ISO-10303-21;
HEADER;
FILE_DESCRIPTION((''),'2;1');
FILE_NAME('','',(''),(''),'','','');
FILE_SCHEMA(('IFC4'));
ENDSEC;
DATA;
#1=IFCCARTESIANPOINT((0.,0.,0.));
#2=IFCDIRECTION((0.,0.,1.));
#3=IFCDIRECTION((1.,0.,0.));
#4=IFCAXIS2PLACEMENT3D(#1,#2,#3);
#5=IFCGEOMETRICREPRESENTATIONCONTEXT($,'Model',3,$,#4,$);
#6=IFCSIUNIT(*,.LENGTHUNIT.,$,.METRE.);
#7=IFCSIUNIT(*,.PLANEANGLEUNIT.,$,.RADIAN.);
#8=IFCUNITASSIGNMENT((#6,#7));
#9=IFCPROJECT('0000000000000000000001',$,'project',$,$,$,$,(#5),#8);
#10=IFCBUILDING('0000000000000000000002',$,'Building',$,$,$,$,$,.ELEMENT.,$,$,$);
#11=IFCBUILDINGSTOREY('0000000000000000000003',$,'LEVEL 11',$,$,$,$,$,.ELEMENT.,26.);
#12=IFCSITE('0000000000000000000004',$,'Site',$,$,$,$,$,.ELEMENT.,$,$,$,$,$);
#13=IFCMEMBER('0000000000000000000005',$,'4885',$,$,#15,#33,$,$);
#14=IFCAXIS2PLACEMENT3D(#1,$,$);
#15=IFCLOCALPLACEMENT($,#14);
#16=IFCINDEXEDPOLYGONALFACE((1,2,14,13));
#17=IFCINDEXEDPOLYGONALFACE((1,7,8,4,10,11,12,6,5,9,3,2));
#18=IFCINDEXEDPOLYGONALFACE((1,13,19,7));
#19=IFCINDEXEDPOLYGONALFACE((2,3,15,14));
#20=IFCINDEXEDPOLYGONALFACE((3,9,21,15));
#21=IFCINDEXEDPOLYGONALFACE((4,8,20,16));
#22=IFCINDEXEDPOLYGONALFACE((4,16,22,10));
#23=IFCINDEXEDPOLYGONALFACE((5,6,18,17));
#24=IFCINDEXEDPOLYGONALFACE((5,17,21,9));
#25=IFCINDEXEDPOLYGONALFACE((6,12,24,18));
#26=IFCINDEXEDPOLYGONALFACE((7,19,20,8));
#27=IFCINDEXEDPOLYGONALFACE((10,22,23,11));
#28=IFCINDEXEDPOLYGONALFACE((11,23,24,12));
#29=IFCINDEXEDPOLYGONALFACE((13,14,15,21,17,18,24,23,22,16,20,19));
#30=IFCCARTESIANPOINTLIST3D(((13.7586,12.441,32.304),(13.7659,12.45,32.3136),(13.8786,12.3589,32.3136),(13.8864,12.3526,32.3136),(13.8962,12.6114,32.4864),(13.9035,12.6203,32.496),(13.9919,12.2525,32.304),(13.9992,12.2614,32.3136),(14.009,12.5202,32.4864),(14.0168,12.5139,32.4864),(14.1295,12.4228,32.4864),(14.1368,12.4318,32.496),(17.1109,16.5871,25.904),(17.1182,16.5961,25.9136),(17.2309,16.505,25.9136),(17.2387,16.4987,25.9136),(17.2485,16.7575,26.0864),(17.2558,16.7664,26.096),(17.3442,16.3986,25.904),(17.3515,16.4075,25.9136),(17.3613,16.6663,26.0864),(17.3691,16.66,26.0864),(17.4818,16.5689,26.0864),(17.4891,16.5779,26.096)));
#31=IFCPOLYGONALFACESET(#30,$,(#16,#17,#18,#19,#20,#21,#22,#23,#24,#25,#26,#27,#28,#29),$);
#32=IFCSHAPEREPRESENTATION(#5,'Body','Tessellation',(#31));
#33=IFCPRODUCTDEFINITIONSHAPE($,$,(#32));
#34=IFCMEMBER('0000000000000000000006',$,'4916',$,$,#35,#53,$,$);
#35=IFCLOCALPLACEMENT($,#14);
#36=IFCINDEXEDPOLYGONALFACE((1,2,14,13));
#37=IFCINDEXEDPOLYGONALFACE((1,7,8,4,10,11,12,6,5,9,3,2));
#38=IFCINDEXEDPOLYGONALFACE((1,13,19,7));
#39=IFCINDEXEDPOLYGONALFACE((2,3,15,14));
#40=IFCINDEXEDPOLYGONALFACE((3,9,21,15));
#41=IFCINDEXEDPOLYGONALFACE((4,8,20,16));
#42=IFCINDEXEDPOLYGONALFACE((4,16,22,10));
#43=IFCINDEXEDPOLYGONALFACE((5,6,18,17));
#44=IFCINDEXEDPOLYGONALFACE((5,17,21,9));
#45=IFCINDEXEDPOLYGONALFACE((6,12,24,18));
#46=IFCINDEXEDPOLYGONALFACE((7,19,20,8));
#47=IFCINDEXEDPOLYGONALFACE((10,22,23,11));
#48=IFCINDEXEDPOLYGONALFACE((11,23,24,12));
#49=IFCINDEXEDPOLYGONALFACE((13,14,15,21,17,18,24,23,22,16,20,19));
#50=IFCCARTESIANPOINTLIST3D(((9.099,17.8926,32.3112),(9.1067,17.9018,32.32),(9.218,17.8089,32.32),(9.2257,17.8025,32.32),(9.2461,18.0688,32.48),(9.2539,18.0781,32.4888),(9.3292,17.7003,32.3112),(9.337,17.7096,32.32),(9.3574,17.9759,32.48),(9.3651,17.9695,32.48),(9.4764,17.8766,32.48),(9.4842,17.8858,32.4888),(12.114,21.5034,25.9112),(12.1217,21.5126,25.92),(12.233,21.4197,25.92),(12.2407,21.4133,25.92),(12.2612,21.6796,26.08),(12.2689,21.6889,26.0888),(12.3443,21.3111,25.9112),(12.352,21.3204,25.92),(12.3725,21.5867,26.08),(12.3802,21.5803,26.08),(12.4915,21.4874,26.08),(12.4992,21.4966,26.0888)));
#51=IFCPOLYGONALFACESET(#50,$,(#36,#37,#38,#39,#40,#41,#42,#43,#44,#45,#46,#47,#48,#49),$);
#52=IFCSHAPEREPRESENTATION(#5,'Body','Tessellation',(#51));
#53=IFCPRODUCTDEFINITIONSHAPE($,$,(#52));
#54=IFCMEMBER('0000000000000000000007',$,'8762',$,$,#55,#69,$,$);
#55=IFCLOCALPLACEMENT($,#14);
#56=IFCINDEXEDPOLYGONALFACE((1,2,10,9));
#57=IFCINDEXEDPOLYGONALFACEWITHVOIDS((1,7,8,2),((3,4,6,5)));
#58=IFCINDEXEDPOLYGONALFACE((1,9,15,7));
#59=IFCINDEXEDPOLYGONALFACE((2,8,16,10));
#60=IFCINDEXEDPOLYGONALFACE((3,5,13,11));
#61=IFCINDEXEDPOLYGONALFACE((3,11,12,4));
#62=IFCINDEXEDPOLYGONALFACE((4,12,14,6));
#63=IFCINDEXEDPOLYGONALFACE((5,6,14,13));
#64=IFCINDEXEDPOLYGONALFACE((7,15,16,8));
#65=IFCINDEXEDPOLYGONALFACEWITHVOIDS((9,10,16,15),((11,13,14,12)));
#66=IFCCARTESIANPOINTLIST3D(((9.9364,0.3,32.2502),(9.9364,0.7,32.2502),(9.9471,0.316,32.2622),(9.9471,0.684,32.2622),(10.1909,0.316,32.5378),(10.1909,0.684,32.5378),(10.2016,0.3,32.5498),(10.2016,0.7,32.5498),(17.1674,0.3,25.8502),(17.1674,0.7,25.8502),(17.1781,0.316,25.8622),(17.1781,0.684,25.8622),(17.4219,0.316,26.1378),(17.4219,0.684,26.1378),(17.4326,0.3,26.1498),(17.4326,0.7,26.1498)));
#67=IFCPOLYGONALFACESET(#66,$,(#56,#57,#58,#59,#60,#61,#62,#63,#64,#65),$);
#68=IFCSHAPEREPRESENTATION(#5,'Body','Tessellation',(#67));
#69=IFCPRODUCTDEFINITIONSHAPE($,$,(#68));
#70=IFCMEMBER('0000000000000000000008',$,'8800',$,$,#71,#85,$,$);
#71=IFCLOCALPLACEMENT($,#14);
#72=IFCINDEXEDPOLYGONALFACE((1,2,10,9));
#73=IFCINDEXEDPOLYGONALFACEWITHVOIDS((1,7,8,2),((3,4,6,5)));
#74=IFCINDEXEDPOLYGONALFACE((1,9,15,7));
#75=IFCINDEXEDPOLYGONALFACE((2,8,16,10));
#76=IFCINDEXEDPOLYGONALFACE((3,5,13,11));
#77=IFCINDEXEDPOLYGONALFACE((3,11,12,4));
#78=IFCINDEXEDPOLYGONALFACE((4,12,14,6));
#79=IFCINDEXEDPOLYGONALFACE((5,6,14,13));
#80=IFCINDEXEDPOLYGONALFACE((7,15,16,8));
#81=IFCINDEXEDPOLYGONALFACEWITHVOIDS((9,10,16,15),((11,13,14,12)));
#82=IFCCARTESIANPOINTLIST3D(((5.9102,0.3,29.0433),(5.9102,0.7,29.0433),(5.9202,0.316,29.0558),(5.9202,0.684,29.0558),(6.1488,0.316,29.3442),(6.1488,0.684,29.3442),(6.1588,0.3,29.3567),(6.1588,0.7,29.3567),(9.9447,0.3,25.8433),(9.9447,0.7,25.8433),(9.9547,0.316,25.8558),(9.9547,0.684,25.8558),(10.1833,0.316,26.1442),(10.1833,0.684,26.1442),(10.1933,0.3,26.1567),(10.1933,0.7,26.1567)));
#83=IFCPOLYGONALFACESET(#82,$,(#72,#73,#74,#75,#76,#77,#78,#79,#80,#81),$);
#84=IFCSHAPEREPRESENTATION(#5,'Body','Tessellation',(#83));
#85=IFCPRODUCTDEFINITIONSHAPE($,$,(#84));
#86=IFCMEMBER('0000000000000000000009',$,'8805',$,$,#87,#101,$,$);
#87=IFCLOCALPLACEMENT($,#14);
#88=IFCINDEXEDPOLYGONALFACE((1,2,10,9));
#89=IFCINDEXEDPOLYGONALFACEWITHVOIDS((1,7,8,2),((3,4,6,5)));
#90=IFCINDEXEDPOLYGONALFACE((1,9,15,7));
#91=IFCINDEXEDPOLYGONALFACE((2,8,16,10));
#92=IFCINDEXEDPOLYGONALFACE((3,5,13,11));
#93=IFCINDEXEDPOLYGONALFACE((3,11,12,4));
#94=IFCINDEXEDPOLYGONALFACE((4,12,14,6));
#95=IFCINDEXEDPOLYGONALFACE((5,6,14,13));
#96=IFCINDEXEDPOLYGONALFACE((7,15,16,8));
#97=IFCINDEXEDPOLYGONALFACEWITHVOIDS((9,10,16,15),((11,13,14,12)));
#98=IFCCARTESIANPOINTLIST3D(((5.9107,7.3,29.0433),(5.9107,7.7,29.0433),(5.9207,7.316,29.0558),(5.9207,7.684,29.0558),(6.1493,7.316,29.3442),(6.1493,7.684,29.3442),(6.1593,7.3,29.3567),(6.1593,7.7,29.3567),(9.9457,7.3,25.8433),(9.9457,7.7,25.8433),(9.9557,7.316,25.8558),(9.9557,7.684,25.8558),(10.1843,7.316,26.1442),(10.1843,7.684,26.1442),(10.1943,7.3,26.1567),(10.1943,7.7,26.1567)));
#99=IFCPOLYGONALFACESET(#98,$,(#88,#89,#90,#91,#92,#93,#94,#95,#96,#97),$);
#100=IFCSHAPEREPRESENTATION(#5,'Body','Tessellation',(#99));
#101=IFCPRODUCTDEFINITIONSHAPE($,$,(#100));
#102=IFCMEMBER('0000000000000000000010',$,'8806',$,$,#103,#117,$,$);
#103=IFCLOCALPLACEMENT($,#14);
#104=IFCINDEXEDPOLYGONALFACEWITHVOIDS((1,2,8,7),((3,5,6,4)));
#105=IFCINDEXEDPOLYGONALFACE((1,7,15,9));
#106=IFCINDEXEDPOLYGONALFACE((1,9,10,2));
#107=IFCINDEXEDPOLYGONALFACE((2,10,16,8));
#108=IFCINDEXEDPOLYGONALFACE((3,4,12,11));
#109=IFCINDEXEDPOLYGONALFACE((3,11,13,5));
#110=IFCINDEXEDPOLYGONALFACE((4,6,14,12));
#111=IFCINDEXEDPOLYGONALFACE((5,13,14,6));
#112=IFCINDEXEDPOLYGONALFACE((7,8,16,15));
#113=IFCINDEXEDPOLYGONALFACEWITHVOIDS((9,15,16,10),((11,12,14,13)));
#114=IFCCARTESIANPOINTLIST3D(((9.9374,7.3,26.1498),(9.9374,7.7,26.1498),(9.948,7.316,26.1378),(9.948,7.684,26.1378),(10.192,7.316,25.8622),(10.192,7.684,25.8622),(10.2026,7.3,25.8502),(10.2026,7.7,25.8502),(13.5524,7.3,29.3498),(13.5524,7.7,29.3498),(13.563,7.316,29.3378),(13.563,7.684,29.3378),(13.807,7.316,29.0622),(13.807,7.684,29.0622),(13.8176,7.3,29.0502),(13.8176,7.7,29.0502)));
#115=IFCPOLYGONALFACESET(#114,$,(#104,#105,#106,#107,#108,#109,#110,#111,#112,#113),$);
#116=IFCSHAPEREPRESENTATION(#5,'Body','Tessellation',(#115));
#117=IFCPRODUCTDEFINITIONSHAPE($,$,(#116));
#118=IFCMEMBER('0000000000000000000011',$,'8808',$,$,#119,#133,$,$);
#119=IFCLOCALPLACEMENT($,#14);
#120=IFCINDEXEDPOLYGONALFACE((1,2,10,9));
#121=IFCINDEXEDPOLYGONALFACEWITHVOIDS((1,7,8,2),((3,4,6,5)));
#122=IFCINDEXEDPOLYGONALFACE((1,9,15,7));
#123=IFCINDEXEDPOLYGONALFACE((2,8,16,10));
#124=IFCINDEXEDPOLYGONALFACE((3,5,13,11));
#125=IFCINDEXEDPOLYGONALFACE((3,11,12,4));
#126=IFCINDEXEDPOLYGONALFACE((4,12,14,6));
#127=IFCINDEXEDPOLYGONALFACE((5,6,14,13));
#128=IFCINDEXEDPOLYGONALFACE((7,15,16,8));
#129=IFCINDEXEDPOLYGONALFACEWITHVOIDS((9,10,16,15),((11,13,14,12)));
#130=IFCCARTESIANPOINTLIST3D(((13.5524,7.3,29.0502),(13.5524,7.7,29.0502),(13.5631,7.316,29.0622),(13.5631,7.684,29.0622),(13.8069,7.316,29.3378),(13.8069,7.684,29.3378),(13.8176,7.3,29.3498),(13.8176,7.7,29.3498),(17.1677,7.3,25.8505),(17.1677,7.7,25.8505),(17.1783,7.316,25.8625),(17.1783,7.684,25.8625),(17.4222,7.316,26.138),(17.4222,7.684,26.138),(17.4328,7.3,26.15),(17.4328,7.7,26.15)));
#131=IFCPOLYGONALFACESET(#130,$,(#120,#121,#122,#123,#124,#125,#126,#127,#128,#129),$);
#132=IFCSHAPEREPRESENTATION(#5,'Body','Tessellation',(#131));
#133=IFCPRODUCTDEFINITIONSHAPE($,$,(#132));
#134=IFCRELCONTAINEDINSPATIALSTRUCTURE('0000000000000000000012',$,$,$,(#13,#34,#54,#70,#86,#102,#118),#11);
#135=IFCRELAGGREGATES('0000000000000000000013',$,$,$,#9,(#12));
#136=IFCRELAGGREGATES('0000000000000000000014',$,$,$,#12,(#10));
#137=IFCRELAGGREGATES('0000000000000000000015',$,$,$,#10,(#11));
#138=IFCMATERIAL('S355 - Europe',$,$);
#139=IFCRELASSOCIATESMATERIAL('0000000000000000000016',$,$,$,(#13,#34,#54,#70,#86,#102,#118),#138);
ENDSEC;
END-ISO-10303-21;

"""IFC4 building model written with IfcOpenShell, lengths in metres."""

from ifc_helpers import new_model, si_unit, frame, origin_with_axes, origin_2d_with_axis, place, context, project, spatial, hollow_rectangle, i_section, extrude, material, material_profile, profile_set, profile_usage, element, save


model = new_model("IFC4")

# Units and contexts
model_context = context("Model", 3, world=origin_with_axes())
ifc_project = project(units=[si_unit("LENGTHUNIT", "METRE"), si_unit("PLANEANGLEUNIT", "RADIAN")], contexts=[model_context])

# Site, building, storey
site = spatial("IfcSite", under=ifc_project, Name="Site", CompositionType="ELEMENT")
building = spatial("IfcBuilding", under=site, Name="Building", CompositionType="ELEMENT")
storey = spatial("IfcBuildingStorey", under=building, Name="LEVEL 11", CompositionType="ELEMENT", Elevation=26.0)

# Shared definitions
ifc_material = material(Name="S355 - Europe")

# Members
ifc_material_profile_1 = material_profile(ifc_material, i_section(OverallWidth=0.3, OverallDepth=0.3, WebThickness=0.01, FlangeThickness=0.015, at=origin_2d_with_axis()))
ifc_profile_set_1 = profile_set([ifc_material_profile_1])
ifc_profile_usage_1 = profile_usage(ifc_profile_set_1, cardinal=10)
member_1_placement = place(None, frame((13.9477, 12.4364, 32.4), z_axis=(0.402439, 0.497734, -0.768312), x_axis=(-0.777826, 0.62848, 0.0)))
element("IfcMember", 1, at=member_1_placement, inside=storey, material=ifc_profile_usage_1, Name="4885", context=model_context, shape_type="SweptSolid", body=[
    extrude(i_section(OverallWidth=0.3, OverallDepth=0.3, WebThickness=0.01, FlangeThickness=0.015, at=origin_2d_with_axis()), origin_with_axes(), (0.0, 0.0, 1.0), 8.3299),
])
ifc_material_profile_2 = material_profile(ifc_material, i_section(OverallWidth=0.3, OverallDepth=0.3, WebThickness=0.01, FlangeThickness=0.015, at=origin_2d_with_axis()))
ifc_profile_set_2 = profile_set([ifc_material_profile_2])
ifc_profile_usage_2 = profile_usage(ifc_profile_set_2, cardinal=10)
member_2_placement = place(None, frame((9.2916, 17.8892, 32.4), z_axis=(0.379593, 0.454599, -0.805759), x_axis=(-0.767589, 0.640942, 0.0)))
element("IfcMember", 2, at=member_2_placement, inside=storey, material=ifc_profile_usage_2, Name="4916", context=model_context, shape_type="SweptSolid", body=[
    extrude(i_section(OverallWidth=0.3, OverallDepth=0.3, WebThickness=0.01, FlangeThickness=0.015, at=origin_2d_with_axis()), origin_with_axes(), (0.0, 0.0, 1.0), 7.9428),
])
ifc_material_profile_3 = material_profile(ifc_material, hollow_rectangle(XDim=0.4, YDim=0.4, WallThickness=0.016, at=origin_2d_with_axis()))
ifc_profile_set_3 = profile_set([ifc_material_profile_3])
ifc_profile_usage_3 = profile_usage(ifc_profile_set_3, cardinal=10)
member_3_placement = place(None, frame((10.069, 0.5, 32.4), z_axis=(0.748825, 0.0, -0.662768), x_axis=(0.0, 1.0, 0.0)))
element("IfcMember", 3, at=member_3_placement, inside=storey, material=ifc_profile_usage_3, Name="8762", context=model_context, shape_type="SweptSolid", body=[
    extrude(hollow_rectangle(XDim=0.4, YDim=0.4, WallThickness=0.016, at=origin_2d_with_axis()), origin_with_axes(), (0.0, 0.0, 1.0), 9.6565),
])
ifc_material_profile_4 = material_profile(ifc_material, hollow_rectangle(XDim=0.4, YDim=0.4, WallThickness=0.016, at=origin_2d_with_axis()))
ifc_profile_set_4 = profile_set([ifc_material_profile_4])
ifc_profile_usage_4 = profile_usage(ifc_profile_set_4, cardinal=10)
member_4_placement = place(None, frame((10.069, 0.5, 26.0), z_axis=(-0.783476, 0.0, 0.621421), x_axis=(0.0, -1.0, 0.0)))
element("IfcMember", 4, at=member_4_placement, inside=storey, material=ifc_profile_usage_4, Name="8800", context=model_context, shape_type="SweptSolid", body=[
    extrude(hollow_rectangle(XDim=0.4, YDim=0.4, WallThickness=0.016, at=origin_2d_with_axis()), origin_with_axes(), (0.0, 0.0, 1.0), 5.1495),
])
ifc_material_profile_5 = material_profile(ifc_material, hollow_rectangle(XDim=0.4, YDim=0.4, WallThickness=0.016, at=origin_2d_with_axis()))
ifc_profile_set_5 = profile_set([ifc_material_profile_5])
ifc_profile_usage_5 = profile_usage(ifc_profile_set_5, cardinal=10)
member_5_placement = place(None, frame((6.035, 7.5, 29.2), z_axis=(0.783514, 0.0, -0.621374), x_axis=(0.0, 1.0, 0.0)))
element("IfcMember", 5, at=member_5_placement, inside=storey, material=ifc_profile_usage_5, Name="8805", context=model_context, shape_type="SweptSolid", body=[
    extrude(hollow_rectangle(XDim=0.4, YDim=0.4, WallThickness=0.016, at=origin_2d_with_axis()), origin_with_axes(), (0.0, 0.0, 1.0), 5.1499),
])
ifc_material_profile_6 = material_profile(ifc_material, hollow_rectangle(XDim=0.4, YDim=0.4, WallThickness=0.016, at=origin_2d_with_axis()))
ifc_profile_set_6 = profile_set([ifc_material_profile_6])
ifc_profile_usage_6 = profile_usage(ifc_profile_set_6, cardinal=10)
member_6_placement = place(None, frame((10.07, 7.5, 26.0), z_axis=(0.748779, 0.0, 0.66282), x_axis=(0.0, 1.0, 0.0)))
element("IfcMember", 6, at=member_6_placement, inside=storey, material=ifc_profile_usage_6, Name="8806", context=model_context, shape_type="SweptSolid", body=[
    extrude(hollow_rectangle(XDim=0.4, YDim=0.4, WallThickness=0.016, at=origin_2d_with_axis()), origin_with_axes(), (0.0, 0.0, 1.0), 4.8279),
])
ifc_material_profile_7 = material_profile(ifc_material, hollow_rectangle(XDim=0.4, YDim=0.4, WallThickness=0.016, at=origin_2d_with_axis()))
ifc_profile_set_7 = profile_set([ifc_material_profile_7])
ifc_profile_usage_7 = profile_usage(ifc_profile_set_7, cardinal=10)
member_7_placement = place(None, frame((13.685, 7.5, 29.2), z_axis=(0.748825, 0.0, -0.662768), x_axis=(0.0, 1.0, 0.0)))
element("IfcMember", 7, at=member_7_placement, inside=storey, material=ifc_profile_usage_7, Name="8808", context=model_context, shape_type="SweptSolid", body=[
    extrude(hollow_rectangle(XDim=0.4, YDim=0.4, WallThickness=0.016, at=origin_2d_with_axis()), origin_with_axes(), (0.0, 0.0, 1.0), 4.8279),
])

save(model, "model.ifc")
